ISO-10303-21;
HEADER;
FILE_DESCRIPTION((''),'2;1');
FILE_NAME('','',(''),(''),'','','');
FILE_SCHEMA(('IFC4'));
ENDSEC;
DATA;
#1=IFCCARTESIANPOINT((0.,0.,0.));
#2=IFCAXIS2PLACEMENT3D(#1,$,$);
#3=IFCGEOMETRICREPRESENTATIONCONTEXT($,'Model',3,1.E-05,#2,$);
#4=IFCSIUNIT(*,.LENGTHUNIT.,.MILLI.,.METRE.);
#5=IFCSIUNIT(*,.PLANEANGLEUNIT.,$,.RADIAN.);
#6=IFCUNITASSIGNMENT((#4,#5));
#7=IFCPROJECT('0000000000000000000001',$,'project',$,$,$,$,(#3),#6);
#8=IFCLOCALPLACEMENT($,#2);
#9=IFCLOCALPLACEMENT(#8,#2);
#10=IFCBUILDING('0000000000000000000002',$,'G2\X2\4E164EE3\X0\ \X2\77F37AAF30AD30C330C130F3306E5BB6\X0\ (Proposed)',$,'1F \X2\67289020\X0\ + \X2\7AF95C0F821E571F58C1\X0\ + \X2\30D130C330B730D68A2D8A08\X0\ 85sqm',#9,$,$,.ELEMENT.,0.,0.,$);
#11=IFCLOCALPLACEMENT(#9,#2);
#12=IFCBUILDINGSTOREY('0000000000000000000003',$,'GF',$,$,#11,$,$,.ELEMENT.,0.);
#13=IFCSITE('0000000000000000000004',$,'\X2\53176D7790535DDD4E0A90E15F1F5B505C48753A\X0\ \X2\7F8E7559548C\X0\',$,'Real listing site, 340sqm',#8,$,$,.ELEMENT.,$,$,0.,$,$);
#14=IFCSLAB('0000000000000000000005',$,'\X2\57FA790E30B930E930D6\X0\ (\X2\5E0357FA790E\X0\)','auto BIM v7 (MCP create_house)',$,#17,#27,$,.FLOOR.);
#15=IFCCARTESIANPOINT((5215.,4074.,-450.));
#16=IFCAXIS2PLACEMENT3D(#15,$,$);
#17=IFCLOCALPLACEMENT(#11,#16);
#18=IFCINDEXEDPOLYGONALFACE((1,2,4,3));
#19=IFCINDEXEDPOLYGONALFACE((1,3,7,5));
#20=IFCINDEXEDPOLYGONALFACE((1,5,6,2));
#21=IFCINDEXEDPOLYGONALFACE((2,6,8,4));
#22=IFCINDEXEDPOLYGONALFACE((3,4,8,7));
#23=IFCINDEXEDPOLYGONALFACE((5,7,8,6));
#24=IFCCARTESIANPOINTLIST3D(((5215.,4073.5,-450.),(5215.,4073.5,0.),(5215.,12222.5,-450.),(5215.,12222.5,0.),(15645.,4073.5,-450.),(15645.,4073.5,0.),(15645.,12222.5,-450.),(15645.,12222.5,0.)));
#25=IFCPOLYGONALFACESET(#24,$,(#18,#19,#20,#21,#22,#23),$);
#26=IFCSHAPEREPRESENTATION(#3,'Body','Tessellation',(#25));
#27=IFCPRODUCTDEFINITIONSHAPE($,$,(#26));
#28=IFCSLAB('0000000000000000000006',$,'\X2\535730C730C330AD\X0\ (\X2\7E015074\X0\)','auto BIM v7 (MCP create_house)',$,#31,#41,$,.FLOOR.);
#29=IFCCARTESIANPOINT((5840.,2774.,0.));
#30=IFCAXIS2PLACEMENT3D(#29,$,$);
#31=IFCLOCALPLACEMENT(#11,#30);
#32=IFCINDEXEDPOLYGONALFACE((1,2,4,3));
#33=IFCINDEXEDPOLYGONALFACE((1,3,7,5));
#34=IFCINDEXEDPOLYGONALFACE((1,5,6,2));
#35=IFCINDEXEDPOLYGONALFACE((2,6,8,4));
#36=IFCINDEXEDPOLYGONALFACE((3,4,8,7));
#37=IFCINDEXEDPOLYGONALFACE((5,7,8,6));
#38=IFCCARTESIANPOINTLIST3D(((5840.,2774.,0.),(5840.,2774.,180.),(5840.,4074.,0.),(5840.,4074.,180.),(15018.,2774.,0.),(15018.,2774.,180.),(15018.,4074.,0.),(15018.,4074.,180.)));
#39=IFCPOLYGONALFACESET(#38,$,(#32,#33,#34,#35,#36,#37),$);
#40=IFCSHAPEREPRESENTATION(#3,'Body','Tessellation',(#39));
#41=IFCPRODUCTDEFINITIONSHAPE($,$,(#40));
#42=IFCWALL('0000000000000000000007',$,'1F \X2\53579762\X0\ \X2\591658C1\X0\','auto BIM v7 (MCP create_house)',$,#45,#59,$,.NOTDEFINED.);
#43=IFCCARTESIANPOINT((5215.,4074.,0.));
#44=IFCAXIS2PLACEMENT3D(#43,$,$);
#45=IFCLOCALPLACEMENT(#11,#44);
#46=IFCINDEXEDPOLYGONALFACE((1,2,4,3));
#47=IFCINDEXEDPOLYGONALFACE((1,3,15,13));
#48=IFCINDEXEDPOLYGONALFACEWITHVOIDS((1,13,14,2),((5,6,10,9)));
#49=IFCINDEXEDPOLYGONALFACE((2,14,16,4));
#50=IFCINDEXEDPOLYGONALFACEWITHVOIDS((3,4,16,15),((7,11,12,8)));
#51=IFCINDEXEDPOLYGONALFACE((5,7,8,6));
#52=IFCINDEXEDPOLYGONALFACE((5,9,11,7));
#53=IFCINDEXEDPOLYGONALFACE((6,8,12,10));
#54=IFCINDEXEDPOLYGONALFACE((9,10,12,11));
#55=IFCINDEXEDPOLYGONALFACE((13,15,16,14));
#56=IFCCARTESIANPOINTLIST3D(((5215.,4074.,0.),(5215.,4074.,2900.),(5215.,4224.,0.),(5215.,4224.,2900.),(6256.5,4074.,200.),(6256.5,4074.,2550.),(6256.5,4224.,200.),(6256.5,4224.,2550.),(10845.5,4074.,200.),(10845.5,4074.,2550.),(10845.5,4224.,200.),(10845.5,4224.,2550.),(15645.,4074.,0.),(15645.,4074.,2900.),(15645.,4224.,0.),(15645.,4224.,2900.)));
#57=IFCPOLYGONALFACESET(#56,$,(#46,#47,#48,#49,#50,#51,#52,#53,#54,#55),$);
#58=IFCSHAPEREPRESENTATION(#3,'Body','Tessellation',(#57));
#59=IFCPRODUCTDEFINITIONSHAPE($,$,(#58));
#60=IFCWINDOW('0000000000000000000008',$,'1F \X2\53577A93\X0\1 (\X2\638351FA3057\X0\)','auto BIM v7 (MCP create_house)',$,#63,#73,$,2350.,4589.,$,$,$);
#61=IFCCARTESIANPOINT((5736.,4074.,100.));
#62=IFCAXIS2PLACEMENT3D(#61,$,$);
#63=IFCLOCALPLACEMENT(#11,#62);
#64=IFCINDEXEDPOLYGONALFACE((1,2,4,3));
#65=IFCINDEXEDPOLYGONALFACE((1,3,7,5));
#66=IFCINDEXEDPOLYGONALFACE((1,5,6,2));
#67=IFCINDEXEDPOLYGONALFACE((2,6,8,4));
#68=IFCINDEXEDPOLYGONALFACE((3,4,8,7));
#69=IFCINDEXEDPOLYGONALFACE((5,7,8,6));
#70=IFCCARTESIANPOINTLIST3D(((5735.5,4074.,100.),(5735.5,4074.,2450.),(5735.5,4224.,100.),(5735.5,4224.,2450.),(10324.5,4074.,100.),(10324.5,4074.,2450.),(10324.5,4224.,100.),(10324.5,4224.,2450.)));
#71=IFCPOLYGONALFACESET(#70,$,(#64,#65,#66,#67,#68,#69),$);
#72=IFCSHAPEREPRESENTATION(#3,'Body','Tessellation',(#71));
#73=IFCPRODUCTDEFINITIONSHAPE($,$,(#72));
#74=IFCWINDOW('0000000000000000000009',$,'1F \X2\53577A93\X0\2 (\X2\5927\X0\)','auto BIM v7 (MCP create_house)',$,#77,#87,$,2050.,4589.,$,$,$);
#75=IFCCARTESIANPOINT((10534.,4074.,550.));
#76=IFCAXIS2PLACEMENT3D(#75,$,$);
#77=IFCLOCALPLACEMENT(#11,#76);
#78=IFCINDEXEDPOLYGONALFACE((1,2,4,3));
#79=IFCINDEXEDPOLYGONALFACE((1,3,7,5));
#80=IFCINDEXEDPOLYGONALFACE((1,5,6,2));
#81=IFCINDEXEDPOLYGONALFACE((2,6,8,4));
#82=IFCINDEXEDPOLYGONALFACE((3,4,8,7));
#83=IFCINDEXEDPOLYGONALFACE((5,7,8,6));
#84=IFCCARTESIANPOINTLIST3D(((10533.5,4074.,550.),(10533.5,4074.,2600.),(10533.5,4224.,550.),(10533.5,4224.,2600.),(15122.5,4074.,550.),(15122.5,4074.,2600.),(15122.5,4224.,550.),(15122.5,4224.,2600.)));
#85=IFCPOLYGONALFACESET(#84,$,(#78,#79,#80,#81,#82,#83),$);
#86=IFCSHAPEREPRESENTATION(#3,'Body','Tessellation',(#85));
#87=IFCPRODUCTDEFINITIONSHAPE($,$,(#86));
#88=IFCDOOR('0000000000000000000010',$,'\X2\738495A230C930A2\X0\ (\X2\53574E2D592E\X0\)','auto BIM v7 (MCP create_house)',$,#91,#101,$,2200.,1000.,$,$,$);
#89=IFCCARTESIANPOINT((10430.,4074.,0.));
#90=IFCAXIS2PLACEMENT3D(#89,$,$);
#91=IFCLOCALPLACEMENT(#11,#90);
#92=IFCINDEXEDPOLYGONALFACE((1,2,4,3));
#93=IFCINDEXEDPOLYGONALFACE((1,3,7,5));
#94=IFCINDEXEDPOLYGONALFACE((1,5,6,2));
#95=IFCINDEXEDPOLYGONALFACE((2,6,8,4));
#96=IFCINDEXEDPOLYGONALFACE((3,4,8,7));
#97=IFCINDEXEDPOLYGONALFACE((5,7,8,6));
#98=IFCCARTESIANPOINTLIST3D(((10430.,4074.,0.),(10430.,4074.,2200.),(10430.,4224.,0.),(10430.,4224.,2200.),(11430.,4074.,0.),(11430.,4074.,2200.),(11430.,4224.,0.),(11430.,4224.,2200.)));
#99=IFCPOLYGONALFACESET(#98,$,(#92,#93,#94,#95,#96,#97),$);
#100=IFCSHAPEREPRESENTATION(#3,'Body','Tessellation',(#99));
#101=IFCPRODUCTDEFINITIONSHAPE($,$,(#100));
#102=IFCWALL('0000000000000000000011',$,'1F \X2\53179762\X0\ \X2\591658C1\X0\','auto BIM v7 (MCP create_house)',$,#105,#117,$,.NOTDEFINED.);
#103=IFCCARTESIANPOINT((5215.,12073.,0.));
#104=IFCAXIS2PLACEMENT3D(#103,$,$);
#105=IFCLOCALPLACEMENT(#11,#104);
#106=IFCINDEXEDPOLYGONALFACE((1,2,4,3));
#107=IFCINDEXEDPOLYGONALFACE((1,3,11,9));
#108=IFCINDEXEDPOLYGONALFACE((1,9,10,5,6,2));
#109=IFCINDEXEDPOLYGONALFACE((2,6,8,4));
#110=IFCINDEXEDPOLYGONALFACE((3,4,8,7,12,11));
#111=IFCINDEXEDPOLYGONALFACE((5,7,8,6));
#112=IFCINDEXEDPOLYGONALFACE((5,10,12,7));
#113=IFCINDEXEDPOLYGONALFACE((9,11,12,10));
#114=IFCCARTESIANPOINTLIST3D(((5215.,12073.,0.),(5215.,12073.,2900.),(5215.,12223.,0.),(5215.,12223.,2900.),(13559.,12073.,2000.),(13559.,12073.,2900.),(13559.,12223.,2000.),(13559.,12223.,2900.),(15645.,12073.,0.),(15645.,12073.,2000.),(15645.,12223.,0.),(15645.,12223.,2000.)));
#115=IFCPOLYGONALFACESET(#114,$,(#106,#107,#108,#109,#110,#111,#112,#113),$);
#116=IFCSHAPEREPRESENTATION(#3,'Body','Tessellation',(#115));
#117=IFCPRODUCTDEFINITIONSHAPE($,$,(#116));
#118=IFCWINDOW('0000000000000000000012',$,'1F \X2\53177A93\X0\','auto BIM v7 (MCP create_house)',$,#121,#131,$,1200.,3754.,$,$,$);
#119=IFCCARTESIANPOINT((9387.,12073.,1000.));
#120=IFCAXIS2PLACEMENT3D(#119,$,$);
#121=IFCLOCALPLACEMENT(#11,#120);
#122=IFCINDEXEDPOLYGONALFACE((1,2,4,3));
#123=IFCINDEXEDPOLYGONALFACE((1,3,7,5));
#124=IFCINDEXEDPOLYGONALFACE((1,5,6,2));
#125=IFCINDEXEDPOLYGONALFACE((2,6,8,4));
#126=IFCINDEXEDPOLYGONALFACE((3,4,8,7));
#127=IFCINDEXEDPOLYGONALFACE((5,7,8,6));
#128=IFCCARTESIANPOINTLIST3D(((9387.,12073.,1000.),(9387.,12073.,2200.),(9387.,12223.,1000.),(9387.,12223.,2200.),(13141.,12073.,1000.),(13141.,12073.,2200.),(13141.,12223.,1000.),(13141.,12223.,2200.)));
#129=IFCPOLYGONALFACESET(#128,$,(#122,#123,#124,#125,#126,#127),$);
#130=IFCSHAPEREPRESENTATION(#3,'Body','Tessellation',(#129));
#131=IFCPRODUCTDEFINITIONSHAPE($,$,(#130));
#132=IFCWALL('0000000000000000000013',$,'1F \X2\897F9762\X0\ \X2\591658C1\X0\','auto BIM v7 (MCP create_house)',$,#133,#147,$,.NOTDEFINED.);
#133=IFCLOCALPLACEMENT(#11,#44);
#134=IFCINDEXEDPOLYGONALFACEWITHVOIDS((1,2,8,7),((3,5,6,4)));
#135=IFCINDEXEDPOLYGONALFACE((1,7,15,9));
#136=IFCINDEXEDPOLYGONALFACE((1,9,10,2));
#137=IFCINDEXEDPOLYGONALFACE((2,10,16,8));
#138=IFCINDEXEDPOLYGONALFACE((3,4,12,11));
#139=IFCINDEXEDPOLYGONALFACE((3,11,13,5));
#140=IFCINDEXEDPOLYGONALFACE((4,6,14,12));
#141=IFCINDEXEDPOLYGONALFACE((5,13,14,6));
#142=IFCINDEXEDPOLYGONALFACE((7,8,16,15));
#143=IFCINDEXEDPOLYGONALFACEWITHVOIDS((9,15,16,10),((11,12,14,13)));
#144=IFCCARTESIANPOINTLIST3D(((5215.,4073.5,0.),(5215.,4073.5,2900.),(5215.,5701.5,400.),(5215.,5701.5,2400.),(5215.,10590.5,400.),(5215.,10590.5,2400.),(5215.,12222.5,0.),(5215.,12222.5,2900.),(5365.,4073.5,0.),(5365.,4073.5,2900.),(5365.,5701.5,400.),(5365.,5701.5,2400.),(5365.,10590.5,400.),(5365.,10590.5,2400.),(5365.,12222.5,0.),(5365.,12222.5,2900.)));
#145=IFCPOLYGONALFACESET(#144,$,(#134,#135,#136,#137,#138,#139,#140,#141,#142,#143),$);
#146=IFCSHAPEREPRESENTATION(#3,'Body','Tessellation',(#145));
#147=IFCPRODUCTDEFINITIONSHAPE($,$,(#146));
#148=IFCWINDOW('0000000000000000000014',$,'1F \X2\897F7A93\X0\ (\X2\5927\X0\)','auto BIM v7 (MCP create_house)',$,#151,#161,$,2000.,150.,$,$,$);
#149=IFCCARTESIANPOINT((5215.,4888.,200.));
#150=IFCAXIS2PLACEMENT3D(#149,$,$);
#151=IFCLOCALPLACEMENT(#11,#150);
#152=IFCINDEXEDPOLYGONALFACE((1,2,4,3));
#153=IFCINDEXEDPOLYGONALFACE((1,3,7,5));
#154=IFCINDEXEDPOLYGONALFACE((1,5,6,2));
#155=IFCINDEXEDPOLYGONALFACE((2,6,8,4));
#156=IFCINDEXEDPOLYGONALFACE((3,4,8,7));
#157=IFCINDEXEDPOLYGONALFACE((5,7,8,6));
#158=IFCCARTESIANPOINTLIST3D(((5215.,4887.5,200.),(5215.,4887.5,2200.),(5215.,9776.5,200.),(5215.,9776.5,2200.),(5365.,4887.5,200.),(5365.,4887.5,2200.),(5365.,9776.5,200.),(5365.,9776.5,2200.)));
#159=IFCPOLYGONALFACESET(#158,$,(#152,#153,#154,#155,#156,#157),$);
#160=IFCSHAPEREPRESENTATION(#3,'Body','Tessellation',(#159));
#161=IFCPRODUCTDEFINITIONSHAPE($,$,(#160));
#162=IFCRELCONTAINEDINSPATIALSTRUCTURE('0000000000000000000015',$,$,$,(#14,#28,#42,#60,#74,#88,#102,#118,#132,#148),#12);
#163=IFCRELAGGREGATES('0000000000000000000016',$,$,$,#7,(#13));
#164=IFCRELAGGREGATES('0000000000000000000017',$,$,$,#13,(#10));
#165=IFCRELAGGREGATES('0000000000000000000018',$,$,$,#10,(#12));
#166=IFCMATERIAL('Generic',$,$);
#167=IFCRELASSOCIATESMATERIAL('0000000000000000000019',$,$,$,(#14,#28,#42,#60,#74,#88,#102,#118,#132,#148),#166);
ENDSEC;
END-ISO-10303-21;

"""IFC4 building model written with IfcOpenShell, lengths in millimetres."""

from ifc_helpers import new_model, si_unit, frame, frame_2d, origin, place, context, project, spatial, rectangle, extrude, material, element, fill, save


model = new_model("IFC4")

# Units and contexts
model_context = context("Model", 3, precision=1e-05, world=origin())
ifc_project = project(units=[si_unit("LENGTHUNIT", "METRE", prefix="MILLI"), si_unit("PLANEANGLEUNIT", "RADIAN")], contexts=[model_context])

# Site, building, storey
site_placement = place(None, origin())
site = spatial("IfcSite", under=ifc_project, at=site_placement, Name="北海道川上郡弟子屈町 美留和", ObjectType="Real listing site, 340sqm", CompositionType="ELEMENT", RefElevation=0.0)
building_placement = place(site_placement, origin())
building = spatial("IfcBuilding", under=site, at=building_placement, Name="G2世代 石窯キッチンの家 (Proposed)", ObjectType="1F 木造 + 竹小舞土壁 + パッシブ設計 85sqm", CompositionType="ELEMENT", ElevationOfRefHeight=0.0, ElevationOfTerrain=0.0)
storey_placement = place(building_placement, origin())
storey = spatial("IfcBuildingStorey", under=building, at=storey_placement, Name="GF", CompositionType="ELEMENT", Elevation=0.0)

# Slabs
ifc_material = material(Name="Generic")
slab_1_placement = place(storey_placement, frame((5215.0, 4074.0, -450.0)))
element("IfcSlab", 1, at=slab_1_placement, inside=storey, material=ifc_material, Name="基礎スラブ (布基礎)", Description="auto BIM v7 (MCP create_house)", PredefinedType="FLOOR", context=model_context, shape_type="SweptSolid", body=[
    extrude(rectangle(XDim=10430.0, YDim=8149.0, at=frame_2d((5215.0, 4074.0))), frame((5215.0, 4074.0, -450.0)), (0.0, 0.0, 1.0), 450.0),
])
slab_2_placement = place(storey_placement, frame((5840.0, 2774.0, 0.0)))
element("IfcSlab", 2, at=slab_2_placement, inside=storey, material=ifc_material, Name="南デッキ (縁側)", Description="auto BIM v7 (MCP create_house)", PredefinedType="FLOOR", context=model_context, shape_type="SweptSolid", body=[
    extrude(rectangle(XDim=9178.0, YDim=1300.0, at=frame_2d((4589.0, 650.0))), frame((5840.0, 2774.0, 0.0)), (0.0, 0.0, 1.0), 180.0),
])

# Wall, openings, windows, door
wall_1_placement = place(storey_placement, frame((5215.0, 4074.0, 0.0)))
wall_1 = element("IfcWall", 3, at=wall_1_placement, inside=storey, material=ifc_material, Name="1F 南面 外壁", Description="auto BIM v7 (MCP create_house)", PredefinedType="NOTDEFINED", context=model_context, shape_type="SweptSolid", body=[
    extrude(rectangle(XDim=10430.0, YDim=150.0, at=frame_2d((5215.0, 75.0))), frame((5215.0, 4074.0, 0.0)), (0.0, 0.0, 1.0), 2900.0),
])
opening_1_placement = place(storey_placement, frame((5736.0, 4074.0, 100.0)))
opening_1 = element("IfcOpeningElement", 4, at=opening_1_placement, cuts=wall_1, PredefinedType="NOTDEFINED", context=model_context, shape_type="SweptSolid", body=[
    extrude(rectangle(XDim=4589.0, YDim=150.0, at=frame_2d((2294.0, 75.0))), frame((5736.0, 4074.0, 100.0)), (0.0, 0.0, 1.0), 2350.0),
])
opening_2_placement = place(storey_placement, frame((10534.0, 4074.0, 550.0)))
opening_2 = element("IfcOpeningElement", 5, at=opening_2_placement, cuts=wall_1, PredefinedType="NOTDEFINED", context=model_context, shape_type="SweptSolid", body=[
    extrude(rectangle(XDim=4589.0, YDim=150.0, at=frame_2d((2294.0, 75.0))), frame((10534.0, 4074.0, 550.0)), (0.0, 0.0, 1.0), 2050.0),
])
opening_3_placement = place(storey_placement, frame((10430.0, 4074.0, 0.0)))
opening_3 = element("IfcOpeningElement", 6, at=opening_3_placement, cuts=wall_1, PredefinedType="NOTDEFINED", context=model_context, shape_type="SweptSolid", body=[
    extrude(rectangle(XDim=1000.0, YDim=150.0, at=frame_2d((500.0, 75.0))), frame((10430.0, 4074.0, 0.0)), (0.0, 0.0, 1.0), 2200.0),
])
window_1_placement = place(storey_placement, frame((5736.0, 4074.0, 100.0)))
window_1 = element("IfcWindow", 7, at=window_1_placement, inside=storey, material=ifc_material, Name="1F 南窓1 (掃出し)", Description="auto BIM v7 (MCP create_house)", OverallHeight=2350.0, OverallWidth=4589.0, context=model_context, shape_type="SweptSolid", body=[
    extrude(rectangle(XDim=4589.0, YDim=150.0, at=frame_2d((2294.0, 75.0))), frame((5736.0, 4074.0, 100.0)), (0.0, 0.0, 1.0), 2350.0),
])
fill(opening_1, window_1)
window_2_placement = place(storey_placement, frame((10534.0, 4074.0, 550.0)))
window_2 = element("IfcWindow", 8, at=window_2_placement, inside=storey, material=ifc_material, Name="1F 南窓2 (大)", Description="auto BIM v7 (MCP create_house)", OverallHeight=2050.0, OverallWidth=4589.0, context=model_context, shape_type="SweptSolid", body=[
    extrude(rectangle(XDim=4589.0, YDim=150.0, at=frame_2d((2294.0, 75.0))), frame((10534.0, 4074.0, 550.0)), (0.0, 0.0, 1.0), 2050.0),
])
fill(opening_2, window_2)
door_placement = place(storey_placement, frame((10430.0, 4074.0, 0.0)))
door = element("IfcDoor", 9, at=door_placement, inside=storey, material=ifc_material, Name="玄関ドア (南中央)", Description="auto BIM v7 (MCP create_house)", OverallHeight=2200.0, OverallWidth=1000.0, context=model_context, shape_type="SweptSolid", body=[
    extrude(rectangle(XDim=1000.0, YDim=150.0, at=frame_2d((500.0, 75.0))), frame((10430.0, 4074.0, 0.0)), (0.0, 0.0, 1.0), 2200.0),
])
fill(opening_3, door)

# Walls, openings, windows
wall_2_placement = place(storey_placement, frame((5215.0, 12073.0, 0.0)))
wall_2 = element("IfcWall", 10, at=wall_2_placement, inside=storey, material=ifc_material, Name="1F 北面 外壁", Description="auto BIM v7 (MCP create_house)", PredefinedType="NOTDEFINED", context=model_context, shape_type="SweptSolid", body=[
    extrude(rectangle(XDim=10430.0, YDim=150.0, at=frame_2d((5215.0, 75.0))), frame((5215.0, 12073.0, 0.0)), (0.0, 0.0, 1.0), 2900.0),
])
opening_4_placement = place(storey_placement, frame((9387.0, 12073.0, 1000.0)))
opening_4 = element("IfcOpeningElement", 11, at=opening_4_placement, cuts=wall_2, PredefinedType="NOTDEFINED", context=model_context, shape_type="SweptSolid", body=[
    extrude(rectangle(XDim=3754.0, YDim=150.0, at=frame_2d((1877.0, 75.0))), frame((9387.0, 12073.0, 1000.0)), (0.0, 0.0, 1.0), 1200.0),
])
window_3_placement = place(storey_placement, frame((9387.0, 12073.0, 1000.0)))
window_3 = element("IfcWindow", 12, at=window_3_placement, inside=storey, material=ifc_material, Name="1F 北窓", Description="auto BIM v7 (MCP create_house)", OverallHeight=1200.0, OverallWidth=3754.0, context=model_context, shape_type="SweptSolid", body=[
    extrude(rectangle(XDim=3754.0, YDim=150.0, at=frame_2d((1877.0, 75.0))), frame((9387.0, 12073.0, 1000.0)), (0.0, 0.0, 1.0), 1200.0),
])
fill(opening_4, window_3)
wall_3_placement = place(storey_placement, frame((5215.0, 4074.0, 0.0)))
wall_3 = element("IfcWall", 13, at=wall_3_placement, inside=storey, material=ifc_material, Name="1F 西面 外壁", Description="auto BIM v7 (MCP create_house)", PredefinedType="NOTDEFINED", context=model_context, shape_type="SweptSolid", body=[
    extrude(rectangle(XDim=150.0, YDim=8149.0, at=frame_2d((75.0, 4074.0))), frame((5215.0, 4074.0, 0.0)), (0.0, 0.0, 1.0), 2900.0),
])
opening_5_placement = place(storey_placement, frame((5215.0, 4888.0, 200.0)))
opening_5 = element("IfcOpeningElement", 14, at=opening_5_placement, cuts=wall_3, PredefinedType="NOTDEFINED", context=model_context, shape_type="SweptSolid", body=[
    extrude(rectangle(XDim=150.0, YDim=4889.0, at=frame_2d((75.0, 2444.0))), frame((5215.0, 4888.0, 200.0)), (0.0, 0.0, 1.0), 2000.0),
])
window_4_placement = place(storey_placement, frame((5215.0, 4888.0, 200.0)))
window_4 = element("IfcWindow", 15, at=window_4_placement, inside=storey, material=ifc_material, Name="1F 西窓 (大)", Description="auto BIM v7 (MCP create_house)", OverallHeight=2000.0, OverallWidth=150.0, context=model_context, shape_type="SweptSolid", body=[
    extrude(rectangle(XDim=150.0, YDim=4889.0, at=frame_2d((75.0, 2444.0))), frame((5215.0, 4888.0, 200.0)), (0.0, 0.0, 1.0), 2000.0),
])
fill(opening_5, window_4)

save(model, "model.ifc")
